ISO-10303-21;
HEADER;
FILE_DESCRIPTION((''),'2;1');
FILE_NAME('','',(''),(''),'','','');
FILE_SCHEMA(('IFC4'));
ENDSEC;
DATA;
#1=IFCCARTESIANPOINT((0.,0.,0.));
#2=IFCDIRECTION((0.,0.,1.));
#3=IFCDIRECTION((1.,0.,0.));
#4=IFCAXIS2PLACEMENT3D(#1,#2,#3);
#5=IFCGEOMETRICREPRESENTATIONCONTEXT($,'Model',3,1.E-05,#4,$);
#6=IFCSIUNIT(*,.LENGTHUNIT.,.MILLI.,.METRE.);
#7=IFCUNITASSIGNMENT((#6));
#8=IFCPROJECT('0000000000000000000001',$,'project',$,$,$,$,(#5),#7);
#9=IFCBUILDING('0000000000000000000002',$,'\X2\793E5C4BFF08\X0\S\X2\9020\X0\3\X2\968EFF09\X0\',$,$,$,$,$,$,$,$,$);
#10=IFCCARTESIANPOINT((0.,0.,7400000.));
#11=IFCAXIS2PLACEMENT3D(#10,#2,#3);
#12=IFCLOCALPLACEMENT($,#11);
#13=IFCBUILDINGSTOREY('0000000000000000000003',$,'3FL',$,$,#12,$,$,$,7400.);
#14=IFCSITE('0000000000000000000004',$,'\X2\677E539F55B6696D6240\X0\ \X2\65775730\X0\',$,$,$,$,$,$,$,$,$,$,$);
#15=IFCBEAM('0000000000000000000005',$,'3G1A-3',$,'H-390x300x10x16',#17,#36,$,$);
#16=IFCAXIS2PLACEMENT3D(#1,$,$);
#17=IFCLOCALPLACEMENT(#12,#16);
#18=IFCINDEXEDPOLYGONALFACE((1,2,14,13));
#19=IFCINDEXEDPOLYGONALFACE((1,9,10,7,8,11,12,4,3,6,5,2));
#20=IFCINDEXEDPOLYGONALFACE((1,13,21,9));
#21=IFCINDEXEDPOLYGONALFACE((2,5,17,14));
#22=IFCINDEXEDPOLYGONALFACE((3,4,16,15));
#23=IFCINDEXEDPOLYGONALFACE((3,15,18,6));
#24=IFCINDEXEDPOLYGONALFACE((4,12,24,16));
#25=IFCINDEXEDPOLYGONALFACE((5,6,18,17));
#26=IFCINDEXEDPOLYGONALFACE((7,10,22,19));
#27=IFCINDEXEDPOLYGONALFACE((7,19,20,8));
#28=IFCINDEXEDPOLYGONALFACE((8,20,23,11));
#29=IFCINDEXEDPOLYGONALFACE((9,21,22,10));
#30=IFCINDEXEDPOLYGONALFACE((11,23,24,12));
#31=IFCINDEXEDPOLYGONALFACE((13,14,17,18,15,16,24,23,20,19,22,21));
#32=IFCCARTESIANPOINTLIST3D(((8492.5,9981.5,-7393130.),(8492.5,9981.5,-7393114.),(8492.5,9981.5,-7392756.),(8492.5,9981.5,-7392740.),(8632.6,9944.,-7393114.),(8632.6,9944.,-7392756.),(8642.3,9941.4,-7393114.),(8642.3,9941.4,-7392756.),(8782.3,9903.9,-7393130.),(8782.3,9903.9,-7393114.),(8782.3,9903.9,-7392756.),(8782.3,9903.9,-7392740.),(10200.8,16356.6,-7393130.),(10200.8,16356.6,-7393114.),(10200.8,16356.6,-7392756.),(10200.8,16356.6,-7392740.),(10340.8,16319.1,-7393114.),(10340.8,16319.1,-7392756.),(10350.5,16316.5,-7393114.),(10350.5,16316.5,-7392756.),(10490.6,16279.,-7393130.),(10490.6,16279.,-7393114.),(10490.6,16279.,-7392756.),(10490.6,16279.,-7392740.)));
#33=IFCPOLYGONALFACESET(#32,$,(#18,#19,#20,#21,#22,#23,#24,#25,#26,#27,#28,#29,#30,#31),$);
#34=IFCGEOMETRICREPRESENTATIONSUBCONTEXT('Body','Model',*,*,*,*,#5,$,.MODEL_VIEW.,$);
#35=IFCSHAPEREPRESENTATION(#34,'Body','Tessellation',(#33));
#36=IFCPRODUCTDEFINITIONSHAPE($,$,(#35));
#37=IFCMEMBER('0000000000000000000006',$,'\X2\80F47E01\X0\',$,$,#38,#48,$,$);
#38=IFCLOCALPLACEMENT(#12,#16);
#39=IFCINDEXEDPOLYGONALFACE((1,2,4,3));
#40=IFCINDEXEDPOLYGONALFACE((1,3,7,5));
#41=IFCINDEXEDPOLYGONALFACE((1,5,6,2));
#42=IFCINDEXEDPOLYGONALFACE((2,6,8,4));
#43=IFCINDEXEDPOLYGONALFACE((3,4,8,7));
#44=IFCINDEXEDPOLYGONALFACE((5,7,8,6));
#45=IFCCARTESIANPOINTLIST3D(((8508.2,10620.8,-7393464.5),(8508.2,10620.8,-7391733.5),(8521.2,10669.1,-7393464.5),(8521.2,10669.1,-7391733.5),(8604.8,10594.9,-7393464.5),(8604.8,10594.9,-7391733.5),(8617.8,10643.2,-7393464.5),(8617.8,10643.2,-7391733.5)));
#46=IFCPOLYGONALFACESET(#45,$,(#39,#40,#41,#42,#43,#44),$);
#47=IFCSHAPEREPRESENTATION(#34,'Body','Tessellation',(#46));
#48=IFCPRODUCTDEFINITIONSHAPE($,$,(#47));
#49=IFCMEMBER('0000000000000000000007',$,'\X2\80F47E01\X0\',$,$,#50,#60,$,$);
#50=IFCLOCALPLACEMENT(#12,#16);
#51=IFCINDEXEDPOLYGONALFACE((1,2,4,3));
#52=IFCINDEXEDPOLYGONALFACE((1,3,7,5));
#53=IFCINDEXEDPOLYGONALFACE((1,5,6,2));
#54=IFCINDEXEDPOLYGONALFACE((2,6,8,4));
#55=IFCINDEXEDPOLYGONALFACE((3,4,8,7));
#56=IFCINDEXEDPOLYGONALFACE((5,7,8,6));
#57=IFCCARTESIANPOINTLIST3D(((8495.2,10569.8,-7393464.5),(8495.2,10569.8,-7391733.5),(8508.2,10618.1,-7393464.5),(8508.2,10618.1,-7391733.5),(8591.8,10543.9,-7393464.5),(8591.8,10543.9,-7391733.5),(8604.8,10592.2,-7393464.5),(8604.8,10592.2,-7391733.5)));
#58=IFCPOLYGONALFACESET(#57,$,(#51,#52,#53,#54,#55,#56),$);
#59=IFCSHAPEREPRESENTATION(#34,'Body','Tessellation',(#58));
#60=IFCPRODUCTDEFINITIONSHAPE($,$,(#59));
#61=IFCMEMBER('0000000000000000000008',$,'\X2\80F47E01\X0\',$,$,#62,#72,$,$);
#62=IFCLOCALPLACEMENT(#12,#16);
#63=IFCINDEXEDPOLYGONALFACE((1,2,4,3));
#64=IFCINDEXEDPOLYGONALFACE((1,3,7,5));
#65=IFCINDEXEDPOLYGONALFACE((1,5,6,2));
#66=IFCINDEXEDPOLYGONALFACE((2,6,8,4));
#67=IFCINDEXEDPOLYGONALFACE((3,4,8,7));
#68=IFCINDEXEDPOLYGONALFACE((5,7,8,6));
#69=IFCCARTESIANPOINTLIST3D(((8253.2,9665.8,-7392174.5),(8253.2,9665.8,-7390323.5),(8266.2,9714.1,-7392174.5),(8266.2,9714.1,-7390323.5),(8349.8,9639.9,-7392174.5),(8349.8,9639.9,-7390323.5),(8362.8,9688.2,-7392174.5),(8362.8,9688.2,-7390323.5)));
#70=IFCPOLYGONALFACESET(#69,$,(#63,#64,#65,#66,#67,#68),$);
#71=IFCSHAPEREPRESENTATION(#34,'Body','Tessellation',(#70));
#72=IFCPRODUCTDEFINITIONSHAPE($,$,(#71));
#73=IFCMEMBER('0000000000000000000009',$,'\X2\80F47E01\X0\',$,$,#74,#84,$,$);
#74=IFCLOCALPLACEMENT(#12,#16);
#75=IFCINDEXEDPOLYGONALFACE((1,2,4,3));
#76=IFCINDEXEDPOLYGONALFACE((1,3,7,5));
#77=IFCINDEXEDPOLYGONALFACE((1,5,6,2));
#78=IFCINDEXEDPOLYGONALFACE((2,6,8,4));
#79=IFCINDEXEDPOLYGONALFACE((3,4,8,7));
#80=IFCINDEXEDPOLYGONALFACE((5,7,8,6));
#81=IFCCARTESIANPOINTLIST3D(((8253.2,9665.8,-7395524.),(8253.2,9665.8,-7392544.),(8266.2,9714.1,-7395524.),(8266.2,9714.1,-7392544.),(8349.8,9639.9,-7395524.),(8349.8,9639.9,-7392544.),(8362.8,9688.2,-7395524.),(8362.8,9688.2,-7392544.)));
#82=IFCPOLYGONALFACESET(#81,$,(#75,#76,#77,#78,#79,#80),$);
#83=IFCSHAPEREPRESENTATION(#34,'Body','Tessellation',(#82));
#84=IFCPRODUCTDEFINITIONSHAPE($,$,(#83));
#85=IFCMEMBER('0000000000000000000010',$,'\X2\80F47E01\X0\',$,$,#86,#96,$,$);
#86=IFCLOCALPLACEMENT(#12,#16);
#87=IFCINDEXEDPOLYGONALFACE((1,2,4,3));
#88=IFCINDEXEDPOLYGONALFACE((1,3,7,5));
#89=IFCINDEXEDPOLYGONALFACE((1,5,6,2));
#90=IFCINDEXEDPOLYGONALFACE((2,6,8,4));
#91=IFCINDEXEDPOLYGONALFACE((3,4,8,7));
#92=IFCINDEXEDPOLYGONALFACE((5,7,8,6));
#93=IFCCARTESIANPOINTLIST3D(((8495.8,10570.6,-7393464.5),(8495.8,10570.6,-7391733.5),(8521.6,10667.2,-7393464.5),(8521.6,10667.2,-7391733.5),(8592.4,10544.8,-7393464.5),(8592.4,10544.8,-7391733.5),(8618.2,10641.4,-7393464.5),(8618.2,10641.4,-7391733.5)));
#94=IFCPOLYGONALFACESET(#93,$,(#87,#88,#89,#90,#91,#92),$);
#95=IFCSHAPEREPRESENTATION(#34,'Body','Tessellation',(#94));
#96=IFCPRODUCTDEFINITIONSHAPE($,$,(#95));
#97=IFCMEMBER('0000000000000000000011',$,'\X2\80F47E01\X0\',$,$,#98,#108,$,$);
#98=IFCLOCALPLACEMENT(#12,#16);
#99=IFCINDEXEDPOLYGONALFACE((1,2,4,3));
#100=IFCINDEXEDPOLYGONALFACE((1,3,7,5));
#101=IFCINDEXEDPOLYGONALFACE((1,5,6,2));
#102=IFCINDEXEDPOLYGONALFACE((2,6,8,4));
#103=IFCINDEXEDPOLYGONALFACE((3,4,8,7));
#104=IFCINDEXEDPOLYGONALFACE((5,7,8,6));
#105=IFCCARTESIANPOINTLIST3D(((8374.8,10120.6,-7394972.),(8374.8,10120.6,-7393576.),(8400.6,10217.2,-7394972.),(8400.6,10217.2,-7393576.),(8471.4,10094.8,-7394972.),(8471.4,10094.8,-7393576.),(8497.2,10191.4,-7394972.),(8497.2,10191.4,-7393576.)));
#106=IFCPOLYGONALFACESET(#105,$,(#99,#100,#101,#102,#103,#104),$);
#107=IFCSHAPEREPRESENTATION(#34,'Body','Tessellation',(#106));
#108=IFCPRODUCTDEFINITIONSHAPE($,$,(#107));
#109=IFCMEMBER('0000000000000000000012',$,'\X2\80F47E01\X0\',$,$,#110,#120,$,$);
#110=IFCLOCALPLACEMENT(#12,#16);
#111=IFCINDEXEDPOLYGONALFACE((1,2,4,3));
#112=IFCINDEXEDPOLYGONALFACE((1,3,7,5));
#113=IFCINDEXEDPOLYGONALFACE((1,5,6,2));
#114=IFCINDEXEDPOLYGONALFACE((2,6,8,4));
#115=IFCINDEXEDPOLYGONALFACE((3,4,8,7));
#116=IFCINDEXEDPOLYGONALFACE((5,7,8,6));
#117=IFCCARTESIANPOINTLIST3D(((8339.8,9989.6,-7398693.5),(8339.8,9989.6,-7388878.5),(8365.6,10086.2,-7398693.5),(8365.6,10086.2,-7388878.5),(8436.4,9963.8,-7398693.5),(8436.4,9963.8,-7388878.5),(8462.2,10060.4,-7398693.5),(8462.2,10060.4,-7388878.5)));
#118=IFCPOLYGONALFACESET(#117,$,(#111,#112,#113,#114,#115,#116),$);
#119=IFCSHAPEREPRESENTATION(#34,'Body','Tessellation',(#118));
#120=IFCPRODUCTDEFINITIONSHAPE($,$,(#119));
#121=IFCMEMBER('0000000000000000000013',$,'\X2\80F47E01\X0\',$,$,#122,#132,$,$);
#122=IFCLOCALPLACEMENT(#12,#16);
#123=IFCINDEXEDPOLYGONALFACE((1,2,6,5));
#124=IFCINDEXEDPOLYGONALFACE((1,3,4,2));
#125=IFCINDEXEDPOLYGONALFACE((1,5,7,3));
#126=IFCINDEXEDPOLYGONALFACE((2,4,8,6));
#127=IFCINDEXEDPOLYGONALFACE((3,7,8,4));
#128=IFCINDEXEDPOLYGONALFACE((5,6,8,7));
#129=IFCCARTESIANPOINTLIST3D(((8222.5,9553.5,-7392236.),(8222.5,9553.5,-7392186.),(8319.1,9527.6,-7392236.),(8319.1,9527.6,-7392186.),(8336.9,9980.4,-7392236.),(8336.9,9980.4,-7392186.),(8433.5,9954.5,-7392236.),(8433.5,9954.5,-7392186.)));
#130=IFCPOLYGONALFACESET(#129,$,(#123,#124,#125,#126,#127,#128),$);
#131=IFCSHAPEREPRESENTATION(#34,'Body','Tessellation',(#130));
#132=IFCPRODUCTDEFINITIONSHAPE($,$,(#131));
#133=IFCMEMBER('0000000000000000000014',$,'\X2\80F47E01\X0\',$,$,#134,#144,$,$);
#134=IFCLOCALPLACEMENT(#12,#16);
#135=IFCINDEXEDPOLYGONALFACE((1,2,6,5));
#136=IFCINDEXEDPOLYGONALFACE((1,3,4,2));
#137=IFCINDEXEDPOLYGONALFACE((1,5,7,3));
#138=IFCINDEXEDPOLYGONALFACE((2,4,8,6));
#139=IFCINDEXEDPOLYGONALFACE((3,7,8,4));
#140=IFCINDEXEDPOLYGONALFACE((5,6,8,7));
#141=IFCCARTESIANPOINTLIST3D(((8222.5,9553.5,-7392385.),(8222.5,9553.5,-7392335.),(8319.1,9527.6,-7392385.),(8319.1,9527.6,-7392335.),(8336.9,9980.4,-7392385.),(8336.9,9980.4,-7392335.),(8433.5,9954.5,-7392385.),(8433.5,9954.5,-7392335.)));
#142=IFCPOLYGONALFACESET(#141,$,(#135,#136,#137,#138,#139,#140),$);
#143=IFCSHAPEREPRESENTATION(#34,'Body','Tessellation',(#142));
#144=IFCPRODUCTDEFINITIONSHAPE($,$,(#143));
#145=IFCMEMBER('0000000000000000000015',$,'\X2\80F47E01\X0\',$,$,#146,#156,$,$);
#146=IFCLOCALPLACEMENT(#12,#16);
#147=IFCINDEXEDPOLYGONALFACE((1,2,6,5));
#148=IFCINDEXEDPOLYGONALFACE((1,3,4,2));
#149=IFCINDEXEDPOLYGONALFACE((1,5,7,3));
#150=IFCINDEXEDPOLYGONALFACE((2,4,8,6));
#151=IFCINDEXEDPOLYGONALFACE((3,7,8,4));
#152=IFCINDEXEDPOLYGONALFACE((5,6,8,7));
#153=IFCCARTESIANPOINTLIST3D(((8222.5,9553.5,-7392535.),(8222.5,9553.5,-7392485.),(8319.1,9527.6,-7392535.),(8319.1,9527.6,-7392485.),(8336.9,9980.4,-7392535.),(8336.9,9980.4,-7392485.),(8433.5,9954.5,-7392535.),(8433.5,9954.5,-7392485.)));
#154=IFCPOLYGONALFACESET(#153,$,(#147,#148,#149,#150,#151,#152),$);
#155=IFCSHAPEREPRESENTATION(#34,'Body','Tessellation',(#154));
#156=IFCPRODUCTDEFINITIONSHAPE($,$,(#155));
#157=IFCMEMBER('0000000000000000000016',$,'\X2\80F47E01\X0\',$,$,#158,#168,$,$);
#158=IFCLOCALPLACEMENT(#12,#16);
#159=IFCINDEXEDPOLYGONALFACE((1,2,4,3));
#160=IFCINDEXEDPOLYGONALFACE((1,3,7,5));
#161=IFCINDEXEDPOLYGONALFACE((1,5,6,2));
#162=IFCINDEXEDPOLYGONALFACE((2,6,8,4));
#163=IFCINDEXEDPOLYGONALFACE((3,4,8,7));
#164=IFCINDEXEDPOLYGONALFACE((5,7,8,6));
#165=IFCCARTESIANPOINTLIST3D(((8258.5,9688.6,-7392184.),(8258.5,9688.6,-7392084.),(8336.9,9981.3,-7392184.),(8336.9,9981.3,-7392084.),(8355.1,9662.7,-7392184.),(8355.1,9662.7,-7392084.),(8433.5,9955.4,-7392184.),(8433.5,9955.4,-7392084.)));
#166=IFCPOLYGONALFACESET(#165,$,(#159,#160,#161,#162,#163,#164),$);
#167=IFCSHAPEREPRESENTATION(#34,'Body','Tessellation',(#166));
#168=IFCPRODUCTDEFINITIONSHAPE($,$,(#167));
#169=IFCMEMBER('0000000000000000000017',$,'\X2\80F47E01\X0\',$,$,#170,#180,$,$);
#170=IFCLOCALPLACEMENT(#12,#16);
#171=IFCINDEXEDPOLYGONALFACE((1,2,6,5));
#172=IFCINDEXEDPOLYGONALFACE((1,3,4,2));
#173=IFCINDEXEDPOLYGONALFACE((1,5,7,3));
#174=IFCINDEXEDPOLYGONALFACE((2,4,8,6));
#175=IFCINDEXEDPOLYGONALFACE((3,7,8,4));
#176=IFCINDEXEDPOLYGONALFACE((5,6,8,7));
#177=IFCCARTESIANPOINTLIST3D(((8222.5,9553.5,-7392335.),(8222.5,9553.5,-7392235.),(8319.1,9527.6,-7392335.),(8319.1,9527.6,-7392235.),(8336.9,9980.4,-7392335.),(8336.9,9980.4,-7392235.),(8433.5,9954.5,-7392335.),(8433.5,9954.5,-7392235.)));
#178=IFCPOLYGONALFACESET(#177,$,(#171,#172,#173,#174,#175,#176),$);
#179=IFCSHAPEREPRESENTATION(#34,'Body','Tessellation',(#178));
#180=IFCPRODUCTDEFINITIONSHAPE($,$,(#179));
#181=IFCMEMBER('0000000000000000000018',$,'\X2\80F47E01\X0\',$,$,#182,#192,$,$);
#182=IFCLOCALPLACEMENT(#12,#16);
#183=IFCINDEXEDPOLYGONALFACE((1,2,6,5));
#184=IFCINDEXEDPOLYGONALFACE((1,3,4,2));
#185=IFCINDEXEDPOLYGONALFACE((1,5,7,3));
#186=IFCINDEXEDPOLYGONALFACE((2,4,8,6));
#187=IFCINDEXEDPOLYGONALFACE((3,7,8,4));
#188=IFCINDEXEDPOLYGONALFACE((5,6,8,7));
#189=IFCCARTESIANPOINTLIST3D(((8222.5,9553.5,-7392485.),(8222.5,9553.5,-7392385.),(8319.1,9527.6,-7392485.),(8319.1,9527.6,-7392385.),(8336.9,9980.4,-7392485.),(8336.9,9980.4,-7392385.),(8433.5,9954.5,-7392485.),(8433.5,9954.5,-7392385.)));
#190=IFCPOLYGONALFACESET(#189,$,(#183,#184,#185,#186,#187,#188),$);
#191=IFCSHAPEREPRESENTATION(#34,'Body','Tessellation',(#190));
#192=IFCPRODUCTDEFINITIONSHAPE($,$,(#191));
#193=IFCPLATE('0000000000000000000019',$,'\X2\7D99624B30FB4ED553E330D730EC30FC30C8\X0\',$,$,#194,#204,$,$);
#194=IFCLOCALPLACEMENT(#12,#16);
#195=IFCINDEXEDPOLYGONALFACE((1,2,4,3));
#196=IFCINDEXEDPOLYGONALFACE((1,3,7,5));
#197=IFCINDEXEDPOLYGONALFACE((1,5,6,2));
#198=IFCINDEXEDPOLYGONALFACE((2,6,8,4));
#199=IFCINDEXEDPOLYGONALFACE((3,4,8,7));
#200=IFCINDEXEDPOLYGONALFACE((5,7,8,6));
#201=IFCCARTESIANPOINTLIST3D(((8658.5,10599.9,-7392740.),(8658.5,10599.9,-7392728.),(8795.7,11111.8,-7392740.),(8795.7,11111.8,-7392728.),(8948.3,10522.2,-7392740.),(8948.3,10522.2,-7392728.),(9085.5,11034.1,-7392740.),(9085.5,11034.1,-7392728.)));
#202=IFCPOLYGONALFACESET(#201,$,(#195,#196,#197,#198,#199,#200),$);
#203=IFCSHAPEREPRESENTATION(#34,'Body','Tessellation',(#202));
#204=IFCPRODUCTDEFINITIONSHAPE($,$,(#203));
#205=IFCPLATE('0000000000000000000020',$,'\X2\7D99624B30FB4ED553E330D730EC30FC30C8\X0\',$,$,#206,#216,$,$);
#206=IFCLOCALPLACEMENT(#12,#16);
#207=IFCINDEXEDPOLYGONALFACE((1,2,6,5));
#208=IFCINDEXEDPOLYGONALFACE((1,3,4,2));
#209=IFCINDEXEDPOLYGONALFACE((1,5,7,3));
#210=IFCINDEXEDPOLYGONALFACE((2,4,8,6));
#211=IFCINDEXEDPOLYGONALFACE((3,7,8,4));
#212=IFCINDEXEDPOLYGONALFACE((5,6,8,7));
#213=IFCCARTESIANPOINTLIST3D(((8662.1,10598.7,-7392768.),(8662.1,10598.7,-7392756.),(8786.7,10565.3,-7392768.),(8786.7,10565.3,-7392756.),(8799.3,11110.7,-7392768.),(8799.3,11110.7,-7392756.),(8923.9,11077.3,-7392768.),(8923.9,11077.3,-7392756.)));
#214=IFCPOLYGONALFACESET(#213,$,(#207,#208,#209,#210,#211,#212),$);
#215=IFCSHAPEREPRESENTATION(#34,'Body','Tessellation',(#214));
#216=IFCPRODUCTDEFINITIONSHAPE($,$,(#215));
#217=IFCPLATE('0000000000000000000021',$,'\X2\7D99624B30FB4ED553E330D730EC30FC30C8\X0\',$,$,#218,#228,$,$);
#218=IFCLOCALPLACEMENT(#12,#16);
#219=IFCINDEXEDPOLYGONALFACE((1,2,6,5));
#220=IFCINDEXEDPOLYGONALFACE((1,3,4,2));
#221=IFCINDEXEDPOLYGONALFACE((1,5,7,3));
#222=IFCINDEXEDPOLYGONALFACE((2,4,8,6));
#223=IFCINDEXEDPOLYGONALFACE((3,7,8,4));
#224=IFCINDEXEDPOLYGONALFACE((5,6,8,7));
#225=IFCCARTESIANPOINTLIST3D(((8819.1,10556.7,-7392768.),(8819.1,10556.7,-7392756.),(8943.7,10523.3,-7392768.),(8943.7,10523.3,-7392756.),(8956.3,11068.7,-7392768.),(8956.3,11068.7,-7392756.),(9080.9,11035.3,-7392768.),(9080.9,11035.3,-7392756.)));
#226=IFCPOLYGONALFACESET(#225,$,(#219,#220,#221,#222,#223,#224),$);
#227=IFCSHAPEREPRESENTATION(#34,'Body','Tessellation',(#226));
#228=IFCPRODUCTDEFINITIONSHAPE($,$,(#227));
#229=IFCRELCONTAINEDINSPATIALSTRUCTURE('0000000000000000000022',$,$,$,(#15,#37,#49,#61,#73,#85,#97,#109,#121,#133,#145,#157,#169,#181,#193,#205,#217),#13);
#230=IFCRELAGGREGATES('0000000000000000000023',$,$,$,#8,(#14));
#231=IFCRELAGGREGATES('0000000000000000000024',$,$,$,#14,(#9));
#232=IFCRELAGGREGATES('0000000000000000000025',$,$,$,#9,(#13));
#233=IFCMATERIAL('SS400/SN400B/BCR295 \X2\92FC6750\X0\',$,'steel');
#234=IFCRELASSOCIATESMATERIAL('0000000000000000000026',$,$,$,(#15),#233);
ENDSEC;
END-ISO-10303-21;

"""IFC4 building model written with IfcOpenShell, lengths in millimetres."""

from ifc_helpers import new_model, si_unit, frame, origin, origin_with_axes, place, context, subcontext, project, spatial, rectangle, i_section, extrude, material, element, save


model = new_model("IFC4")

# Units and contexts
model_context = context("Model", 3, precision=1e-05, world=origin_with_axes())
body_context = subcontext(model_context, "Body", "Model", "MODEL_VIEW")
ifc_project = project(units=[si_unit("LENGTHUNIT", "METRE", prefix="MILLI")], contexts=[model_context])

# Site, building, storey
site = spatial("IfcSite", under=ifc_project, Name="松原営業所 敷地")
building = spatial("IfcBuilding", under=site, Name="社屋（S造3階）")
storey_placement = place(None, frame((0.0, 0.0, 7400000.0), z_axis=(0.0, 0.0, 1.0), x_axis=(1.0, 0.0, 0.0)))
storey = spatial("IfcBuildingStorey", under=building, at=storey_placement, Name="3FL", Elevation=7400.0)

# Beam
ifc_material = material(Name="SS400/SN400B/BCR295 鋼材", Category="steel")
beam_placement = place(storey_placement, frame((8637.4, 9942.7, -7392740.0), z_axis=(0.258825, 0.965924, 0.0), x_axis=(-0.965924, 0.258825, 0.0)))
element("IfcBeam", 1, at=beam_placement, inside=storey, material=ifc_material, Name="3G1A-3", ObjectType="H-390x300x10x16", context=body_context, shape_type="SweptSolid", body=[
    extrude(i_section(OverallWidth=300.0, OverallDepth=390.0, WebThickness=10.0, FlangeThickness=16.0), frame((0.0, -195.0, 0.0)), (0.0, 0.0, 1.0), 6600.0),
])

# Members
for number, where, z_axis, x_axis, name in (
    (2, (8569.5, 10656.1, -7392599.0), (-0.258819, -0.965926, 0.0), (0.965926, -0.258819, 0.0), "胴縁"),
    (3, (8556.5, 10605.1, -7392599.0), (-0.258819, -0.965926, 0.0), (0.965926, -0.258819, 0.0), "胴縁"),
):
    element("IfcMember", number, at=place(storey_placement, frame(where, z_axis=z_axis, x_axis=x_axis)), inside=storey, Name=name, context=body_context, shape_type="SweptSolid", body=[
        extrude(rectangle(XDim=100.0, YDim=1731.0), origin(), (0.0, 0.0, 1.0), 50.0),
    ])
member_1_placement = place(storey_placement, frame((8314.5, 9701.1, -7391249.0), z_axis=(-0.258819, -0.965926, 0.0), x_axis=(0.965926, -0.258819, 0.0)))
element("IfcMember", 4, at=member_1_placement, inside=storey, Name="胴縁", context=body_context, shape_type="SweptSolid", body=[
    extrude(rectangle(XDim=100.0, YDim=1851.0), origin(), (0.0, 0.0, 1.0), 50.0),
])
member_2_placement = place(storey_placement, frame((8314.5, 9701.1, -7394034.0), z_axis=(-0.258819, -0.965926, 0.0), x_axis=(0.965926, -0.258819, 0.0)))
element("IfcMember", 5, at=member_2_placement, inside=storey, Name="胴縁", context=body_context, shape_type="SweptSolid", body=[
    extrude(rectangle(XDim=100.0, YDim=2980.0), origin(), (0.0, 0.0, 1.0), 50.0),
])
member_3_placement = place(storey_placement, frame((8569.9, 10654.3, -7392599.0), z_axis=(-0.258819, -0.965926, 0.0), x_axis=(0.965926, -0.258819, 0.0)))
element("IfcMember", 6, at=member_3_placement, inside=storey, Name="胴縁", context=body_context, shape_type="SweptSolid", body=[
    extrude(rectangle(XDim=100.0, YDim=1731.0), origin(), (0.0, 0.0, 1.0), 100.0),
])
member_4_placement = place(storey_placement, frame((8448.9, 10204.3, -7394274.0), z_axis=(-0.258819, -0.965926, 0.0), x_axis=(0.965926, -0.258819, 0.0)))
element("IfcMember", 7, at=member_4_placement, inside=storey, Name="胴縁", context=body_context, shape_type="SweptSolid", body=[
    extrude(rectangle(XDim=100.0, YDim=1396.0), origin(), (0.0, 0.0, 1.0), 100.0),
])
member_5_placement = place(storey_placement, frame((8413.9, 10073.3, -7393786.0), z_axis=(-0.258819, -0.965926, 0.0), x_axis=(0.965926, -0.258819, 0.0)))
element("IfcMember", 8, at=member_5_placement, inside=storey, Name="胴縁", context=body_context, shape_type="SweptSolid", body=[
    extrude(rectangle(XDim=100.0, YDim=9815.0), origin(), (0.0, 0.0, 1.0), 100.0),
])
for number, where, z_axis, x_axis, name in (
    (9, (8385.2, 9967.5, -7392211.0), (-0.258819, -0.965926, 0.0), (0.965926, -0.258819, 0.0), "胴縁"),
    (10, (8385.2, 9967.5, -7392360.0), (-0.258819, -0.965926, 0.0), (0.965926, -0.258819, 0.0), "胴縁"),
    (11, (8385.2, 9967.5, -7392510.0), (-0.258819, -0.965926, 0.0), (0.965926, -0.258819, 0.0), "胴縁"),
):
    element("IfcMember", number, at=place(storey_placement, frame(where, z_axis=z_axis, x_axis=x_axis)), inside=storey, Name=name, context=body_context, shape_type="SweptSolid", body=[
        extrude(rectangle(XDim=100.0, YDim=50.0), origin(), (0.0, 0.0, 1.0), 442.0),
    ])
member_6_placement = place(storey_placement, frame((8385.2, 9968.3, -7392134.0), z_axis=(-0.258819, -0.965926, 0.0), x_axis=(0.965926, -0.258819, 0.0)))
element("IfcMember", 12, at=member_6_placement, inside=storey, Name="胴縁", context=body_context, shape_type="SweptSolid", body=[
    extrude(rectangle(XDim=100.0, YDim=100.0), origin(), (0.0, 0.0, 1.0), 303.0),
])
for number, where, z_axis, x_axis, name in (
    (13, (8385.2, 9967.5, -7392285.0), (-0.258819, -0.965926, 0.0), (0.965926, -0.258819, 0.0), "胴縁"),
    (14, (8385.2, 9967.5, -7392435.0), (-0.258819, -0.965926, 0.0), (0.965926, -0.258819, 0.0), "胴縁"),
):
    element("IfcMember", number, at=place(storey_placement, frame(where, z_axis=z_axis, x_axis=x_axis)), inside=storey, Name=name, context=body_context, shape_type="SweptSolid", body=[
        extrude(rectangle(XDim=100.0, YDim=100.0), origin(), (0.0, 0.0, 1.0), 442.0),
    ])

# Plates
plate_1_placement = place(storey_placement, frame((8803.4, 10561.0, -7392734.0), z_axis=(0.258819, 0.965926, 0.0), x_axis=(-0.965926, 0.258819, 0.0)))
element("IfcPlate", 15, at=plate_1_placement, inside=storey, Name="継手・仕口プレート", context=body_context, shape_type="SweptSolid", body=[
    extrude(rectangle(XDim=300.0, YDim=12.0), origin(), (0.0, 0.0, 1.0), 530.0),
])
for number, where, z_axis, x_axis, name in (
    (16, (8724.4, 10582.0, -7392762.0), (0.258819, 0.965926, 0.0), (-0.965926, 0.258819, 0.0), "継手・仕口プレート"),
    (17, (8881.4, 10540.0, -7392762.0), (0.258819, 0.965926, 0.0), (-0.965926, 0.258819, 0.0), "継手・仕口プレート"),
):
    element("IfcPlate", number, at=place(storey_placement, frame(where, z_axis=z_axis, x_axis=x_axis)), inside=storey, Name=name, context=body_context, shape_type="SweptSolid", body=[
        extrude(rectangle(XDim=129.0, YDim=12.0), origin(), (0.0, 0.0, 1.0), 530.0),
    ])

save(model, "model.ifc")
